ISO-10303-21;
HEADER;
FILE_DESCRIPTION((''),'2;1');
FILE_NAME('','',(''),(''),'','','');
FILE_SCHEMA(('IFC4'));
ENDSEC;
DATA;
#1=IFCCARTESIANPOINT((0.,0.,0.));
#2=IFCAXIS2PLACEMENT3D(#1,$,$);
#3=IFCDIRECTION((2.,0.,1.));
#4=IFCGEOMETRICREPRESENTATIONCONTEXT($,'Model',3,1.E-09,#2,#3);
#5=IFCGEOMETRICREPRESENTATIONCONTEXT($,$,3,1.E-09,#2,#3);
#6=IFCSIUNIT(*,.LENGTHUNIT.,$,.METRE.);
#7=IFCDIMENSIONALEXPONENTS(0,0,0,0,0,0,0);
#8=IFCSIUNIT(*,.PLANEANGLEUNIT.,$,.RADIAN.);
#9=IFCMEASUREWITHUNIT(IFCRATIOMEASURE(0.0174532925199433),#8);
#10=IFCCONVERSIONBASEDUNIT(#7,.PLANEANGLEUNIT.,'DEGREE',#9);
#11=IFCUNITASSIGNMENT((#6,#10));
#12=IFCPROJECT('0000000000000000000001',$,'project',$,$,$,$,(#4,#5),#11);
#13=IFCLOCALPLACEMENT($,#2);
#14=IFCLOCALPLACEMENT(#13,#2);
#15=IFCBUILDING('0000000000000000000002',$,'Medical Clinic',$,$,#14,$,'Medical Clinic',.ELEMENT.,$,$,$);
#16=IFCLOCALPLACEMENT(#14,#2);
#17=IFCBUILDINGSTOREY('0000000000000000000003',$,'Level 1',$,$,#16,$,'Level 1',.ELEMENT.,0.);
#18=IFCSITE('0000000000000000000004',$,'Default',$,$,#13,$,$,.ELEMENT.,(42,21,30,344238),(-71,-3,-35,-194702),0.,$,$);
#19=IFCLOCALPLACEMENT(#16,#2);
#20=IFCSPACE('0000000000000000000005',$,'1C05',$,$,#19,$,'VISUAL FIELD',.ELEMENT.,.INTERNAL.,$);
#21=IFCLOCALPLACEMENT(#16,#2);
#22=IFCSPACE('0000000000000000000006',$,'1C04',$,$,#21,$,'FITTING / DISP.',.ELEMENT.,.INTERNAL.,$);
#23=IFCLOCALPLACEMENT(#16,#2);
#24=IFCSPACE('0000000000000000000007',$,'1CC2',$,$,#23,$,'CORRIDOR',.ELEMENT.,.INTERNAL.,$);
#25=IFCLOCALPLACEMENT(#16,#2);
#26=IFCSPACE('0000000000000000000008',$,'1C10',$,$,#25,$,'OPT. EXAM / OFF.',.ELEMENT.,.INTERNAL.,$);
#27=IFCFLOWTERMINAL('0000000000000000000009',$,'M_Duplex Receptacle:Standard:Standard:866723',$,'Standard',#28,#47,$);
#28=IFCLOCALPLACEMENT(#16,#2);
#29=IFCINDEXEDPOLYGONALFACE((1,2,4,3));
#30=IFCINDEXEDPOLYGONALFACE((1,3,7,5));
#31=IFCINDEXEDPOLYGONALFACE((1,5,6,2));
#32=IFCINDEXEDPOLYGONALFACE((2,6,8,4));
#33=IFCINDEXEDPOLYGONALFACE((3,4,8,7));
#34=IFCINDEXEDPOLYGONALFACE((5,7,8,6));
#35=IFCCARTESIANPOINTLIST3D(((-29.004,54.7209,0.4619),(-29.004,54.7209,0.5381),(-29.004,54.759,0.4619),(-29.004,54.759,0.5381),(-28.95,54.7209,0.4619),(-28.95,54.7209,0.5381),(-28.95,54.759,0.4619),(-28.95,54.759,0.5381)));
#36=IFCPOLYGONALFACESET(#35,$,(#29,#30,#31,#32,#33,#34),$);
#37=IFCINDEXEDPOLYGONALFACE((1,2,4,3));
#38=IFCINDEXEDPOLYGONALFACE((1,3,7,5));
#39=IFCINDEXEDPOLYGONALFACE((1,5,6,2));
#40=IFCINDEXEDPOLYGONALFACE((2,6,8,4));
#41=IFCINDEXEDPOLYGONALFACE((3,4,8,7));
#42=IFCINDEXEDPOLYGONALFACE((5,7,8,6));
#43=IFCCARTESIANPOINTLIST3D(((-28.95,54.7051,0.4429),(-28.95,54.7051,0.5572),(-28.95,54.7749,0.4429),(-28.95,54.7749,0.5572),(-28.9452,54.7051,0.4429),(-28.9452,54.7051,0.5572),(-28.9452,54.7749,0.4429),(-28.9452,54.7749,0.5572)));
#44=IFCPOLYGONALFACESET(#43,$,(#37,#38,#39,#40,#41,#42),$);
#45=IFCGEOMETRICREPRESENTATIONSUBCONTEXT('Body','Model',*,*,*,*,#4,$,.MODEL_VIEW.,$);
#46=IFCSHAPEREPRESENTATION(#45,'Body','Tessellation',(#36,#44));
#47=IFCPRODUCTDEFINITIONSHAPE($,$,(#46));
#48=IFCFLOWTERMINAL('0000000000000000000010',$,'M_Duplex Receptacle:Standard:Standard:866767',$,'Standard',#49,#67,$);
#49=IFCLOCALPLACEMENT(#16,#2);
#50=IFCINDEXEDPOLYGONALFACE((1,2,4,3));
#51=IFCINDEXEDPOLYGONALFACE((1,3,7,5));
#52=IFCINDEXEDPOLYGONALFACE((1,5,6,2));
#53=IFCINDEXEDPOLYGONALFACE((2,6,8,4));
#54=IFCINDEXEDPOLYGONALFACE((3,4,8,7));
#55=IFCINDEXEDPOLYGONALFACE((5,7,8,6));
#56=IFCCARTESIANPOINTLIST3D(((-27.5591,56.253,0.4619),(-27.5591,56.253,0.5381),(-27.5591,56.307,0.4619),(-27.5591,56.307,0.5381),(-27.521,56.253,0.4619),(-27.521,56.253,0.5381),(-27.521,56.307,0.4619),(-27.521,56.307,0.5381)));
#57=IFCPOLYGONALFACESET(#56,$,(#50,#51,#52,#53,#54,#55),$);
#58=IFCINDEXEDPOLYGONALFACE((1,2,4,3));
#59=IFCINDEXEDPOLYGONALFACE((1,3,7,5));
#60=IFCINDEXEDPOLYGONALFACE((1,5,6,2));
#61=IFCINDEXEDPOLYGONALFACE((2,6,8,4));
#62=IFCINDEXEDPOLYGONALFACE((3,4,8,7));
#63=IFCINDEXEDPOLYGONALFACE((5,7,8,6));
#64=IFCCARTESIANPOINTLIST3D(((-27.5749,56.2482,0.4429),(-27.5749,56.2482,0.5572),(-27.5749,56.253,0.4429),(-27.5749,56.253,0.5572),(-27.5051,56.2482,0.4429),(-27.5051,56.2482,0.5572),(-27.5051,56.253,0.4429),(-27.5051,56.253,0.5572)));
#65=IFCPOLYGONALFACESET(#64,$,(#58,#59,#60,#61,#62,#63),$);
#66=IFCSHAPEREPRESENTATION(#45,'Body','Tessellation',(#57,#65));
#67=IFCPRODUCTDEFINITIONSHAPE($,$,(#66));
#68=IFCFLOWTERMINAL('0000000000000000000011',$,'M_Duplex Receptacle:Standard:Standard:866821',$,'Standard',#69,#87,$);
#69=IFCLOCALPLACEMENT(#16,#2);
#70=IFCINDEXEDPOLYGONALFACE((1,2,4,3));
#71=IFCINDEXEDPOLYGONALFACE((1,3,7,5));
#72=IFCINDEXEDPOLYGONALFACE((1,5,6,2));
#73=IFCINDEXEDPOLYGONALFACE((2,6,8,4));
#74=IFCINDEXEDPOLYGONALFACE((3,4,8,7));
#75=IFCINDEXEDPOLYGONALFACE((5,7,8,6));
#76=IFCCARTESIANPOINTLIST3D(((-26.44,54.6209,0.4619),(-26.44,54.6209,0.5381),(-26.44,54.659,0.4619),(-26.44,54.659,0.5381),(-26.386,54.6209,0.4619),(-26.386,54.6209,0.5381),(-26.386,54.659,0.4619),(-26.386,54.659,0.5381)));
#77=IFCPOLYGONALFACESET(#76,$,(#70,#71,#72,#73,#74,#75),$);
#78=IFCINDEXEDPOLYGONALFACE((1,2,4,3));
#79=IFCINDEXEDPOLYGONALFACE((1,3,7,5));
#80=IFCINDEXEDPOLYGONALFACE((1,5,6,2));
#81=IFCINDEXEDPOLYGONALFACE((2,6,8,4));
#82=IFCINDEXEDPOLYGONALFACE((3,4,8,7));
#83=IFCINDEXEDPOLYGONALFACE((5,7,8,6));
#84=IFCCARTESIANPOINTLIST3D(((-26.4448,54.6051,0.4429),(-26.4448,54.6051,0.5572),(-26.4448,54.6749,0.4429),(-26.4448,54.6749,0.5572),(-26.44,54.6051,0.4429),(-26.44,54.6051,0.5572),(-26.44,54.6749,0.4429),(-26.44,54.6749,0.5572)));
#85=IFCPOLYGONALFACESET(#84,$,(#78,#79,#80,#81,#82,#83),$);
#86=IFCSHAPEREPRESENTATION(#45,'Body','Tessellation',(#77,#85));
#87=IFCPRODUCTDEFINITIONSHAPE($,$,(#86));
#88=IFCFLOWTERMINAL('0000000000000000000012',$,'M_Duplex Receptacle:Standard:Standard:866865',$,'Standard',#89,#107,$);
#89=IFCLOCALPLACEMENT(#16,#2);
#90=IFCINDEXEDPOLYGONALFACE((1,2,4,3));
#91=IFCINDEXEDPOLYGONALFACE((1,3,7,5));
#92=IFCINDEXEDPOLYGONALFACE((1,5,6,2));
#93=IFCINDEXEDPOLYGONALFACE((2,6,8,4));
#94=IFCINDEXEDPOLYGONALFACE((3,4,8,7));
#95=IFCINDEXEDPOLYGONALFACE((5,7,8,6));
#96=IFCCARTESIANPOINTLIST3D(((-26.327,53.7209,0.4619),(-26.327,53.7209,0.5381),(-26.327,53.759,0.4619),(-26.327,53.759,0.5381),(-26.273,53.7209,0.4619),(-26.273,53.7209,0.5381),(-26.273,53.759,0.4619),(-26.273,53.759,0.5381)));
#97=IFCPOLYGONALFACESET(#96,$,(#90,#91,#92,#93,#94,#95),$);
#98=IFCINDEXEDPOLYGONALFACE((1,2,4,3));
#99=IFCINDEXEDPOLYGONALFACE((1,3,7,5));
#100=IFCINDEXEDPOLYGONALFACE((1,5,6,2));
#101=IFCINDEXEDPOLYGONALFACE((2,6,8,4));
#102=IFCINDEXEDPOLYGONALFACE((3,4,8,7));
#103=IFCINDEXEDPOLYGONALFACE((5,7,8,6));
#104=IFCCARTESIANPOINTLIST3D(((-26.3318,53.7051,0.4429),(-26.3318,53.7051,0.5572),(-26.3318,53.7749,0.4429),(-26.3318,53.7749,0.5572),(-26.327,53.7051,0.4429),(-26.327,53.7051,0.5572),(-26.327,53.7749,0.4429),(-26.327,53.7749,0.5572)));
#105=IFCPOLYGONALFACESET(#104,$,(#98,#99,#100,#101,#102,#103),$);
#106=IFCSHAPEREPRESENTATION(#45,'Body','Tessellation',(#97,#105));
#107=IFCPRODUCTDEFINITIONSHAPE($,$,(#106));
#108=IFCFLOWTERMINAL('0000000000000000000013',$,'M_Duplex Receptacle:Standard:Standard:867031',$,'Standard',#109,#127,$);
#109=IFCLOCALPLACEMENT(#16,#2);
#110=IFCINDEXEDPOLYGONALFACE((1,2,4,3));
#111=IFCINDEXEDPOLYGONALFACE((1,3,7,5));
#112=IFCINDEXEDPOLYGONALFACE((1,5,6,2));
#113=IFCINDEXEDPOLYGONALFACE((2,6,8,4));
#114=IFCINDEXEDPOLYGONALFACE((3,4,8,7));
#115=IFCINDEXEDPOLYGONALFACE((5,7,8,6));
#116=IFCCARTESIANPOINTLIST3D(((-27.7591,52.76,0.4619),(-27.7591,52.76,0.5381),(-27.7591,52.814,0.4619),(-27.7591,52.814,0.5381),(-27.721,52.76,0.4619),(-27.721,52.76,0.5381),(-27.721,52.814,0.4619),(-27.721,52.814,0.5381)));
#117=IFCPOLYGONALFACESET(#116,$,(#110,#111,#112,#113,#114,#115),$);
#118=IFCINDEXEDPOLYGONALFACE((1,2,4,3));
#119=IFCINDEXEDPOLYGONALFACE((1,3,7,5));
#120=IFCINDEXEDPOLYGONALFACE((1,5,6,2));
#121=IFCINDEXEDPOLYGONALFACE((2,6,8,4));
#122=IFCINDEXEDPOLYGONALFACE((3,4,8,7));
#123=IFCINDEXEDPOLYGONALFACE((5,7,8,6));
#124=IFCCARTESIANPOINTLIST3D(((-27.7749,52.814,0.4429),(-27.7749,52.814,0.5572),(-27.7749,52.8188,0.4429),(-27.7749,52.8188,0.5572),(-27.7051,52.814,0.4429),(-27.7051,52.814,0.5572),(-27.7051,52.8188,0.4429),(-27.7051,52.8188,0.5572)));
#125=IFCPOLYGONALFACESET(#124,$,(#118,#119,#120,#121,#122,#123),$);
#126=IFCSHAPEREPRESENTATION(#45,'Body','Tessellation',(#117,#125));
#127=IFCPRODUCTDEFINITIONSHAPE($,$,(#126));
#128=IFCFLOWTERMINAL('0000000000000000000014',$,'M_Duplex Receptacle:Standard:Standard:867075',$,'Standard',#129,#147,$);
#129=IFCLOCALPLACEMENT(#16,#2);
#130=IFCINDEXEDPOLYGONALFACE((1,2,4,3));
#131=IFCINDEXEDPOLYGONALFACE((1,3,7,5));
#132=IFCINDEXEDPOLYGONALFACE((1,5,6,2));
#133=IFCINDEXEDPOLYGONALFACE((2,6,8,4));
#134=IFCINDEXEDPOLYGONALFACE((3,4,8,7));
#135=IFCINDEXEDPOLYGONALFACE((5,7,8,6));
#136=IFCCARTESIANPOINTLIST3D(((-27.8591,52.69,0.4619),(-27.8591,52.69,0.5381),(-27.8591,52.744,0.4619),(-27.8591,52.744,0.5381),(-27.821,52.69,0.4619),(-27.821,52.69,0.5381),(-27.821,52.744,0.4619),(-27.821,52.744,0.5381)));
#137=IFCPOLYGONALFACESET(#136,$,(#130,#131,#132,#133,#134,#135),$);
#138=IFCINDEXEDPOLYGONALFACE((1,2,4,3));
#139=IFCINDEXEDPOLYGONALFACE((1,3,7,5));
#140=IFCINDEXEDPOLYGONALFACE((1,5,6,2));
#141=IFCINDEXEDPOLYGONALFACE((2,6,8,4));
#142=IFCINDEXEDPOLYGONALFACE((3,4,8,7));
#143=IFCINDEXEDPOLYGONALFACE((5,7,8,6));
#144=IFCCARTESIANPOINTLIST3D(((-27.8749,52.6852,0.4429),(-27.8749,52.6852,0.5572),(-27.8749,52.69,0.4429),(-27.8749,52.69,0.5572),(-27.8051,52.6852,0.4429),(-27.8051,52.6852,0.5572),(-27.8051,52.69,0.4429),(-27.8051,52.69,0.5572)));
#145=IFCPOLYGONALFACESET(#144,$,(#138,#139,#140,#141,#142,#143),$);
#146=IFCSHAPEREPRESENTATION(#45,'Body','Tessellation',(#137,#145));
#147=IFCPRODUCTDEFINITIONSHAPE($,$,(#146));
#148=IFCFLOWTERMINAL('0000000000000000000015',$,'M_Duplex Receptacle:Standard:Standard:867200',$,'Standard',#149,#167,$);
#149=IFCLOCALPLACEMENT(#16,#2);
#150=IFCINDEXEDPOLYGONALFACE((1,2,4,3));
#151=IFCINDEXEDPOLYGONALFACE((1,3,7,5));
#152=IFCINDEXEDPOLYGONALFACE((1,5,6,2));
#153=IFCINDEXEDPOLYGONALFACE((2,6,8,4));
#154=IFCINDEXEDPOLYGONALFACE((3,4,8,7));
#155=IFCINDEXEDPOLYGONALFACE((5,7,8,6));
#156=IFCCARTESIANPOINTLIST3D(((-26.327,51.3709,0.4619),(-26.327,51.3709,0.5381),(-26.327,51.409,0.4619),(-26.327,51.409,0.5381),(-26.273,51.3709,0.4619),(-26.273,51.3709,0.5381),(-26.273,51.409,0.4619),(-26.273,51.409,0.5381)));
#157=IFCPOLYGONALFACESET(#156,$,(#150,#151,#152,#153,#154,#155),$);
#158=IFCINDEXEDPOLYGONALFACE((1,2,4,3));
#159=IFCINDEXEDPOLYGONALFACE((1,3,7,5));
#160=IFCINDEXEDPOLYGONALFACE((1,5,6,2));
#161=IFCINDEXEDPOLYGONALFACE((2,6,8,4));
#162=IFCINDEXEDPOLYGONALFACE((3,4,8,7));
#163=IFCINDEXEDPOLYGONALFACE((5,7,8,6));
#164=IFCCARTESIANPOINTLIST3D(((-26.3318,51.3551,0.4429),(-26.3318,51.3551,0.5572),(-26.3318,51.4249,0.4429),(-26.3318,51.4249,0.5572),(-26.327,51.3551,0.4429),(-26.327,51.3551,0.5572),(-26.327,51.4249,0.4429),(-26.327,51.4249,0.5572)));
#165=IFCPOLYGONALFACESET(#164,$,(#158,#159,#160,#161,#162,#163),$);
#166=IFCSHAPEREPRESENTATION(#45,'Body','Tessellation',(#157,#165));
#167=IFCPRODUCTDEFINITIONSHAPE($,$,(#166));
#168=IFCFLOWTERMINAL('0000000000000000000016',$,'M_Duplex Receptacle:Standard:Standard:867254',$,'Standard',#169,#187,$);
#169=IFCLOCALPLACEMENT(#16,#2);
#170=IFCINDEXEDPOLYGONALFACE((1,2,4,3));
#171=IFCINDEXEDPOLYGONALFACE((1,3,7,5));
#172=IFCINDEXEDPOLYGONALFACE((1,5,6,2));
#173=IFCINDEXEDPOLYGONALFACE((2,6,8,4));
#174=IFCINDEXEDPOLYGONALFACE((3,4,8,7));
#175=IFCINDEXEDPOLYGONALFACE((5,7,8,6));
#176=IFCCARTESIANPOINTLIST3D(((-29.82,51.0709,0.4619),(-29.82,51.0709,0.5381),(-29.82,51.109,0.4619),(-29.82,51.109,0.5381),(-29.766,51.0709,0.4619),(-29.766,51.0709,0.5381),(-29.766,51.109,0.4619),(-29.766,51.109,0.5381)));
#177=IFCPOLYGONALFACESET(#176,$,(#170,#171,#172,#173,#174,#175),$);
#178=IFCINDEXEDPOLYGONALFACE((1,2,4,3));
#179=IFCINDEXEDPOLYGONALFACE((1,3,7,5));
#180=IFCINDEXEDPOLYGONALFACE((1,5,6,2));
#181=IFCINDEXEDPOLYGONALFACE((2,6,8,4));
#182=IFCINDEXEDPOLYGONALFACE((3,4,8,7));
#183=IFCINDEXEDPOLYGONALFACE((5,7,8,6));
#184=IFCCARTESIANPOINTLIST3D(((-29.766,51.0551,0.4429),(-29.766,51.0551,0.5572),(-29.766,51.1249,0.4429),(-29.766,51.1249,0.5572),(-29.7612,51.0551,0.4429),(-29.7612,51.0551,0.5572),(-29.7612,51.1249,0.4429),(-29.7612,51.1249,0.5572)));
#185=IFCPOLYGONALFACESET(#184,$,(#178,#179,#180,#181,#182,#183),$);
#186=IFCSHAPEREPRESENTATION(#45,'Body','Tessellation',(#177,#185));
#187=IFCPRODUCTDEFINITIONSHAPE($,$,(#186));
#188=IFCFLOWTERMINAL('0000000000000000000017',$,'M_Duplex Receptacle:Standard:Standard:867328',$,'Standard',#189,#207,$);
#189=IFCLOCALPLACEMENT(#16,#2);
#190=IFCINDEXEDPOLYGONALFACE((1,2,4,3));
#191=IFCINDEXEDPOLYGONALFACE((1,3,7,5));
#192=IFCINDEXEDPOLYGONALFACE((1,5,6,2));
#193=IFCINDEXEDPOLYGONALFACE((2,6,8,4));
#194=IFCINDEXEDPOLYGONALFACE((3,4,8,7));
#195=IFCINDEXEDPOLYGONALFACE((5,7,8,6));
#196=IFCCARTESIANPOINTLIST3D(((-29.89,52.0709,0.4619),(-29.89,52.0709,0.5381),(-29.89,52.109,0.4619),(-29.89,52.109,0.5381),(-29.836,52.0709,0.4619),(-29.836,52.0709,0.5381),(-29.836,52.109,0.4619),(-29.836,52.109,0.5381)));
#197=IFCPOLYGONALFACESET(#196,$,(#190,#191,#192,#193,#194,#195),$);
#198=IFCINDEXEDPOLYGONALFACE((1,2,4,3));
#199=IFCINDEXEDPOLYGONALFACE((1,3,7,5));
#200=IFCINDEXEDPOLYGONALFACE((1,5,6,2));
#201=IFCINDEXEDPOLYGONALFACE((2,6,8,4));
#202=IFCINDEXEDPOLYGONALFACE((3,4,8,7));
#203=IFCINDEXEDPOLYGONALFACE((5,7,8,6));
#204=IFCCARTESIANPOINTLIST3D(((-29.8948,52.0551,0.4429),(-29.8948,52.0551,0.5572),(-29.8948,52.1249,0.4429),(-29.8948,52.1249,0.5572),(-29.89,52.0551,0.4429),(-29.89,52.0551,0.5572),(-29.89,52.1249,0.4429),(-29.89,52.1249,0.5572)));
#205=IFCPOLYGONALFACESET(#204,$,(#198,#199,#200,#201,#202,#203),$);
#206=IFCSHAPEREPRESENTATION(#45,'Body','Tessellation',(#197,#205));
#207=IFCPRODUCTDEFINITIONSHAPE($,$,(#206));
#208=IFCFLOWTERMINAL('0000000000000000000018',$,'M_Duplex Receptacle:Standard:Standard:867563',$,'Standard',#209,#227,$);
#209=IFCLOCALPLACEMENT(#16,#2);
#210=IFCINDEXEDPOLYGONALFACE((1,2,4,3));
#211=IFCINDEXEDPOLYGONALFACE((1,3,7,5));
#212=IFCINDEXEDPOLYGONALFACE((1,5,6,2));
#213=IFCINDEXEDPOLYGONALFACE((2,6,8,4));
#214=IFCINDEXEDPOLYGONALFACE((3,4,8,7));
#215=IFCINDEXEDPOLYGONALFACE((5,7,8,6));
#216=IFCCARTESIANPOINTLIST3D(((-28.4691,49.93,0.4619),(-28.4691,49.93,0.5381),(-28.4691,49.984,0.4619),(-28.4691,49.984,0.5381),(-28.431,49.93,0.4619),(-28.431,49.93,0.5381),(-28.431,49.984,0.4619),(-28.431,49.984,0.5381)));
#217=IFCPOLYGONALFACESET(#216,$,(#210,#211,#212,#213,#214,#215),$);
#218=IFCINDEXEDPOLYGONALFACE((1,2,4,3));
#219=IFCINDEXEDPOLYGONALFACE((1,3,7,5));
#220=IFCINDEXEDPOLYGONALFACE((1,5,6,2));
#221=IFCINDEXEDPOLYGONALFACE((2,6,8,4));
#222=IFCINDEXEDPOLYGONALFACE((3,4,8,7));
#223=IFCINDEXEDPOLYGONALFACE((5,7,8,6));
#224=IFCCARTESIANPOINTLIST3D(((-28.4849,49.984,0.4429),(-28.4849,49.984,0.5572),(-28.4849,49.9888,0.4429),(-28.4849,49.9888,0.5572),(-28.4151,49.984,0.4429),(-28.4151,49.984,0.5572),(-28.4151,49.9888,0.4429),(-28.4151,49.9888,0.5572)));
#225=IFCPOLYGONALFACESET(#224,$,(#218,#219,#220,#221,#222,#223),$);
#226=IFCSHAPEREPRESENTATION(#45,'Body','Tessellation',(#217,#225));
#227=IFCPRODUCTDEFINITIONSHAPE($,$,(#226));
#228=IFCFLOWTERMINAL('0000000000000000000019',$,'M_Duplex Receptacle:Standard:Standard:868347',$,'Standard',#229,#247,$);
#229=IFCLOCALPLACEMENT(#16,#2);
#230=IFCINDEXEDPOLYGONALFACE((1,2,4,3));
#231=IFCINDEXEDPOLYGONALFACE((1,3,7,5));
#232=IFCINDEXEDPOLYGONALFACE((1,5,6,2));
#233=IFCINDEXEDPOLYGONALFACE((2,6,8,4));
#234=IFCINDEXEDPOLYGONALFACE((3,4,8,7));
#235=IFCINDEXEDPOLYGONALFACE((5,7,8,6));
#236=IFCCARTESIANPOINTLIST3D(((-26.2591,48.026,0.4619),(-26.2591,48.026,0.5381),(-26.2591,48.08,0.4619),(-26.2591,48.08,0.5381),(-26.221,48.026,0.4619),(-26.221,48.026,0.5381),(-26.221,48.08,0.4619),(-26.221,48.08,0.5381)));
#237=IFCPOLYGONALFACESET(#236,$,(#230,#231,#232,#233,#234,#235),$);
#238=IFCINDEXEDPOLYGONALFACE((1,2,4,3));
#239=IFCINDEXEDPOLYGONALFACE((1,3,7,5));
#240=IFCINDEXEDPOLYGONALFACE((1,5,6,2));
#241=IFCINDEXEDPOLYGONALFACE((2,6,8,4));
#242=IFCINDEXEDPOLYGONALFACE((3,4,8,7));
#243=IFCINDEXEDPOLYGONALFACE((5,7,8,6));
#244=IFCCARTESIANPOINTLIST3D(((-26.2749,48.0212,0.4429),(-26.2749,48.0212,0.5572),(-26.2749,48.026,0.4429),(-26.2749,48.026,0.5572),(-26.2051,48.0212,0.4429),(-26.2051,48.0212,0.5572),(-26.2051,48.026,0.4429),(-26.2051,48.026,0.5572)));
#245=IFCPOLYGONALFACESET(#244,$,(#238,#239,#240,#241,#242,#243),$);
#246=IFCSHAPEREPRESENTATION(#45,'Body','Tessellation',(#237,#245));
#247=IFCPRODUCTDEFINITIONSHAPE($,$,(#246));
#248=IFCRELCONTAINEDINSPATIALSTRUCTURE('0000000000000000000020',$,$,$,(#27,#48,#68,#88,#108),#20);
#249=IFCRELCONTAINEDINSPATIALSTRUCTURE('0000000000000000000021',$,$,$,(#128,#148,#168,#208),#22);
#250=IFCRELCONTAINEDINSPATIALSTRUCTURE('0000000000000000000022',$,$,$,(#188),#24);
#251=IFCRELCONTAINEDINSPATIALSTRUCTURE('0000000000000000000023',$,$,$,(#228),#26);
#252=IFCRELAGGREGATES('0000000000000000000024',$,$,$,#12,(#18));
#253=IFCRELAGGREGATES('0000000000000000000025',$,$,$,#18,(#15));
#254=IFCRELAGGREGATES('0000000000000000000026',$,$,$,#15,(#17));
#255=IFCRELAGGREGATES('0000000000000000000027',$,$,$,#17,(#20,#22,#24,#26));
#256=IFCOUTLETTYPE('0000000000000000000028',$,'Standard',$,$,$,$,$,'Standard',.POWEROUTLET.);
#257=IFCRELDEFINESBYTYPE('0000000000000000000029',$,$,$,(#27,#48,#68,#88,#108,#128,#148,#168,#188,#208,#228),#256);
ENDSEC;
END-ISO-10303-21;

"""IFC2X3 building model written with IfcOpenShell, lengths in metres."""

from ifc_helpers import new_model, entity, si_unit, converted_unit, direction, frame, frame_2d, origin, origin_2d_with_axis, place, context, subcontext, project, spatial, rectangle, extrude, source, transform, mapped, type_object, type_shapes, element, save


model = new_model("IFC2X3")

# Units and contexts
model_context = context("Model", 3, precision=1e-09, world=origin(), true_north=direction((2.0, 0.0, 1.0)))
context_of_model = context(None, 3, precision=1e-09, world=origin(), true_north=direction((2.0, 0.0, 1.0)))
body_context = subcontext(model_context, "Body", "Model", "MODEL_VIEW")
ifc_project = project(units=[si_unit("LENGTHUNIT", "METRE"), converted_unit("PLANEANGLEUNIT", "DEGREE", entity("IfcRatioMeasure", 0.0174532925199433), si_unit("PLANEANGLEUNIT", "RADIAN"), dimensions=[0, 0, 0, 0, 0, 0, 0])], contexts=[model_context, context_of_model])

# Site, building, storey, space
site_placement = place(None, origin())
site = spatial("IfcSite", under=ifc_project, at=site_placement, Name="Default", CompositionType="ELEMENT", RefLatitude=(42, 21, 30, 344238), RefLongitude=(-71, -3, -35, -194702), RefElevation=0.0)
building_placement = place(site_placement, origin())
building = spatial("IfcBuilding", under=site, at=building_placement, Name="Medical Clinic", LongName="Medical Clinic", CompositionType="ELEMENT")
storey_placement = place(building_placement, origin())
storey = spatial("IfcBuildingStorey", under=building, at=storey_placement, Name="Level 1", LongName="Level 1", CompositionType="ELEMENT", Elevation=0.0)
space_1_placement = place(storey_placement, origin())
space_1 = spatial("IfcSpace", under=storey, at=space_1_placement, Name="1C05", LongName="VISUAL FIELD", CompositionType="ELEMENT", InteriorOrExteriorSpace="INTERNAL")

# Flow terminals
outlet_type = type_object("IfcOutletType", Name="Standard", ElementType="Standard", PredefinedType="POWEROUTLET")
shared_shape_1 = source(origin(), body_context, "Body", "SweptSolid", [
    extrude(rectangle(XDim=0.0381, YDim=0.0762, at=origin_2d_with_axis()), frame((0.0, 0.0, -0.054), z_axis=(0.0, 0.0, 1.0), x_axis=(-1.0, 0.0, 0.0)), (0.0, 0.0, 1.0), 0.054),
    extrude(rectangle(XDim=0.0698, YDim=0.1143, at=frame_2d((0.0, 0.0), x_axis=(1.0, 0.0))), frame((0.0, 0.0, 0.0), z_axis=(0.0, 0.0, 1.0), x_axis=(-1.0, 0.0, 0.0)), (0.0, 0.0, 1.0), 0.0048),
])
type_shapes(outlet_type, [shared_shape_1])
for number, where, z_axis, x_axis, name in (
    (1, (-28.95, 54.74, 0.5), (1.0, 0.0, 0.0), (0.0, 1.0, 0.0), "M_Duplex Receptacle:Standard:Standard:866723"),
    (2, (-27.54, 56.253, 0.5), (0.0, -1.0, 0.0), (1.0, 0.0, 0.0), "M_Duplex Receptacle:Standard:Standard:866767"),
    (3, (-26.44, 54.64, 0.5), (-1.0, 0.0, 0.0), (0.0, -1.0, 0.0), "M_Duplex Receptacle:Standard:Standard:866821"),
    (4, (-26.327, 53.74, 0.5), (-1.0, 0.0, 0.0), (0.0, -1.0, 0.0), "M_Duplex Receptacle:Standard:Standard:866865"),
    (5, (-27.74, 52.814, 0.5), (0.0, 1.0, 0.0), (-1.0, 0.0, 0.0), "M_Duplex Receptacle:Standard:Standard:867031"),
):
    element("IfcFlowTerminal", number, at=place(space_1_placement, frame(where, z_axis=z_axis, x_axis=x_axis)), inside=space_1, type_object=outlet_type, Name=name, ObjectType="Standard", context=body_context, shape_type="MappedRepresentation", body=[
        mapped(shared_shape_1, transform((0.0, 0.0, 0.0), scale=1.0)),
    ])

# Shared definitions
space_2_placement = place(storey_placement, origin())
space_2 = spatial("IfcSpace", under=storey, at=space_2_placement, Name="1C04", LongName="FITTING / DISP.", CompositionType="ELEMENT", InteriorOrExteriorSpace="INTERNAL")

# Flow terminals
for number, where, z_axis, x_axis, name in (
    (6, (-27.84, 52.69, 0.5), (0.0, -1.0, 0.0), (1.0, 0.0, 0.0), "M_Duplex Receptacle:Standard:Standard:867075"),
    (7, (-26.327, 51.39, 0.5), (-1.0, 0.0, 0.0), (0.0, -1.0, 0.0), "M_Duplex Receptacle:Standard:Standard:867200"),
    (8, (-29.766, 51.09, 0.5), (1.0, 0.0, 0.0), (0.0, 1.0, 0.0), "M_Duplex Receptacle:Standard:Standard:867254"),
):
    element("IfcFlowTerminal", number, at=place(space_2_placement, frame(where, z_axis=z_axis, x_axis=x_axis)), inside=space_2, type_object=outlet_type, Name=name, ObjectType="Standard", context=body_context, shape_type="MappedRepresentation", body=[
        mapped(shared_shape_1, transform((0.0, 0.0, 0.0), scale=1.0)),
    ])

# Shared definitions
space_3_placement = place(storey_placement, origin())
space_3 = spatial("IfcSpace", under=storey, at=space_3_placement, Name="1CC2", LongName="CORRIDOR", CompositionType="ELEMENT", InteriorOrExteriorSpace="INTERNAL")

# Flow terminals
flow_terminal_1_placement = place(space_3_placement, frame((-29.89, 52.09, 0.5), z_axis=(-1.0, 0.0, 0.0), x_axis=(0.0, -1.0, 0.0)))
element("IfcFlowTerminal", 9, at=flow_terminal_1_placement, inside=space_3, type_object=outlet_type, Name="M_Duplex Receptacle:Standard:Standard:867328", ObjectType="Standard", context=body_context, shape_type="MappedRepresentation", body=[
    mapped(shared_shape_1, transform((0.0, 0.0, 0.0), scale=1.0)),
])
flow_terminal_2_placement = place(space_2_placement, frame((-28.45, 49.984, 0.5), z_axis=(0.0, 1.0, 0.0), x_axis=(-1.0, 0.0, 0.0)))
element("IfcFlowTerminal", 10, at=flow_terminal_2_placement, inside=space_2, type_object=outlet_type, Name="M_Duplex Receptacle:Standard:Standard:867563", ObjectType="Standard", context=body_context, shape_type="MappedRepresentation", body=[
    mapped(shared_shape_1, transform((0.0, 0.0, 0.0), scale=1.0)),
])

# Shared definitions
space_4_placement = place(storey_placement, origin())
space_4 = spatial("IfcSpace", under=storey, at=space_4_placement, Name="1C10", LongName="OPT. EXAM / OFF.", CompositionType="ELEMENT", InteriorOrExteriorSpace="INTERNAL")

# Flow terminal
for number, where, z_axis, x_axis, name in (
    (11, (-26.24, 48.026, 0.5), (0.0, -1.0, 0.0), (1.0, 0.0, 0.0), "M_Duplex Receptacle:Standard:Standard:868347"),
):
    element("IfcFlowTerminal", number, at=place(space_4_placement, frame(where, z_axis=z_axis, x_axis=x_axis)), inside=space_4, type_object=outlet_type, Name=name, ObjectType="Standard", context=body_context, shape_type="MappedRepresentation", body=[
        mapped(shared_shape_1, transform((0.0, 0.0, 0.0), scale=1.0)),
    ])

save(model, "model.ifc")
